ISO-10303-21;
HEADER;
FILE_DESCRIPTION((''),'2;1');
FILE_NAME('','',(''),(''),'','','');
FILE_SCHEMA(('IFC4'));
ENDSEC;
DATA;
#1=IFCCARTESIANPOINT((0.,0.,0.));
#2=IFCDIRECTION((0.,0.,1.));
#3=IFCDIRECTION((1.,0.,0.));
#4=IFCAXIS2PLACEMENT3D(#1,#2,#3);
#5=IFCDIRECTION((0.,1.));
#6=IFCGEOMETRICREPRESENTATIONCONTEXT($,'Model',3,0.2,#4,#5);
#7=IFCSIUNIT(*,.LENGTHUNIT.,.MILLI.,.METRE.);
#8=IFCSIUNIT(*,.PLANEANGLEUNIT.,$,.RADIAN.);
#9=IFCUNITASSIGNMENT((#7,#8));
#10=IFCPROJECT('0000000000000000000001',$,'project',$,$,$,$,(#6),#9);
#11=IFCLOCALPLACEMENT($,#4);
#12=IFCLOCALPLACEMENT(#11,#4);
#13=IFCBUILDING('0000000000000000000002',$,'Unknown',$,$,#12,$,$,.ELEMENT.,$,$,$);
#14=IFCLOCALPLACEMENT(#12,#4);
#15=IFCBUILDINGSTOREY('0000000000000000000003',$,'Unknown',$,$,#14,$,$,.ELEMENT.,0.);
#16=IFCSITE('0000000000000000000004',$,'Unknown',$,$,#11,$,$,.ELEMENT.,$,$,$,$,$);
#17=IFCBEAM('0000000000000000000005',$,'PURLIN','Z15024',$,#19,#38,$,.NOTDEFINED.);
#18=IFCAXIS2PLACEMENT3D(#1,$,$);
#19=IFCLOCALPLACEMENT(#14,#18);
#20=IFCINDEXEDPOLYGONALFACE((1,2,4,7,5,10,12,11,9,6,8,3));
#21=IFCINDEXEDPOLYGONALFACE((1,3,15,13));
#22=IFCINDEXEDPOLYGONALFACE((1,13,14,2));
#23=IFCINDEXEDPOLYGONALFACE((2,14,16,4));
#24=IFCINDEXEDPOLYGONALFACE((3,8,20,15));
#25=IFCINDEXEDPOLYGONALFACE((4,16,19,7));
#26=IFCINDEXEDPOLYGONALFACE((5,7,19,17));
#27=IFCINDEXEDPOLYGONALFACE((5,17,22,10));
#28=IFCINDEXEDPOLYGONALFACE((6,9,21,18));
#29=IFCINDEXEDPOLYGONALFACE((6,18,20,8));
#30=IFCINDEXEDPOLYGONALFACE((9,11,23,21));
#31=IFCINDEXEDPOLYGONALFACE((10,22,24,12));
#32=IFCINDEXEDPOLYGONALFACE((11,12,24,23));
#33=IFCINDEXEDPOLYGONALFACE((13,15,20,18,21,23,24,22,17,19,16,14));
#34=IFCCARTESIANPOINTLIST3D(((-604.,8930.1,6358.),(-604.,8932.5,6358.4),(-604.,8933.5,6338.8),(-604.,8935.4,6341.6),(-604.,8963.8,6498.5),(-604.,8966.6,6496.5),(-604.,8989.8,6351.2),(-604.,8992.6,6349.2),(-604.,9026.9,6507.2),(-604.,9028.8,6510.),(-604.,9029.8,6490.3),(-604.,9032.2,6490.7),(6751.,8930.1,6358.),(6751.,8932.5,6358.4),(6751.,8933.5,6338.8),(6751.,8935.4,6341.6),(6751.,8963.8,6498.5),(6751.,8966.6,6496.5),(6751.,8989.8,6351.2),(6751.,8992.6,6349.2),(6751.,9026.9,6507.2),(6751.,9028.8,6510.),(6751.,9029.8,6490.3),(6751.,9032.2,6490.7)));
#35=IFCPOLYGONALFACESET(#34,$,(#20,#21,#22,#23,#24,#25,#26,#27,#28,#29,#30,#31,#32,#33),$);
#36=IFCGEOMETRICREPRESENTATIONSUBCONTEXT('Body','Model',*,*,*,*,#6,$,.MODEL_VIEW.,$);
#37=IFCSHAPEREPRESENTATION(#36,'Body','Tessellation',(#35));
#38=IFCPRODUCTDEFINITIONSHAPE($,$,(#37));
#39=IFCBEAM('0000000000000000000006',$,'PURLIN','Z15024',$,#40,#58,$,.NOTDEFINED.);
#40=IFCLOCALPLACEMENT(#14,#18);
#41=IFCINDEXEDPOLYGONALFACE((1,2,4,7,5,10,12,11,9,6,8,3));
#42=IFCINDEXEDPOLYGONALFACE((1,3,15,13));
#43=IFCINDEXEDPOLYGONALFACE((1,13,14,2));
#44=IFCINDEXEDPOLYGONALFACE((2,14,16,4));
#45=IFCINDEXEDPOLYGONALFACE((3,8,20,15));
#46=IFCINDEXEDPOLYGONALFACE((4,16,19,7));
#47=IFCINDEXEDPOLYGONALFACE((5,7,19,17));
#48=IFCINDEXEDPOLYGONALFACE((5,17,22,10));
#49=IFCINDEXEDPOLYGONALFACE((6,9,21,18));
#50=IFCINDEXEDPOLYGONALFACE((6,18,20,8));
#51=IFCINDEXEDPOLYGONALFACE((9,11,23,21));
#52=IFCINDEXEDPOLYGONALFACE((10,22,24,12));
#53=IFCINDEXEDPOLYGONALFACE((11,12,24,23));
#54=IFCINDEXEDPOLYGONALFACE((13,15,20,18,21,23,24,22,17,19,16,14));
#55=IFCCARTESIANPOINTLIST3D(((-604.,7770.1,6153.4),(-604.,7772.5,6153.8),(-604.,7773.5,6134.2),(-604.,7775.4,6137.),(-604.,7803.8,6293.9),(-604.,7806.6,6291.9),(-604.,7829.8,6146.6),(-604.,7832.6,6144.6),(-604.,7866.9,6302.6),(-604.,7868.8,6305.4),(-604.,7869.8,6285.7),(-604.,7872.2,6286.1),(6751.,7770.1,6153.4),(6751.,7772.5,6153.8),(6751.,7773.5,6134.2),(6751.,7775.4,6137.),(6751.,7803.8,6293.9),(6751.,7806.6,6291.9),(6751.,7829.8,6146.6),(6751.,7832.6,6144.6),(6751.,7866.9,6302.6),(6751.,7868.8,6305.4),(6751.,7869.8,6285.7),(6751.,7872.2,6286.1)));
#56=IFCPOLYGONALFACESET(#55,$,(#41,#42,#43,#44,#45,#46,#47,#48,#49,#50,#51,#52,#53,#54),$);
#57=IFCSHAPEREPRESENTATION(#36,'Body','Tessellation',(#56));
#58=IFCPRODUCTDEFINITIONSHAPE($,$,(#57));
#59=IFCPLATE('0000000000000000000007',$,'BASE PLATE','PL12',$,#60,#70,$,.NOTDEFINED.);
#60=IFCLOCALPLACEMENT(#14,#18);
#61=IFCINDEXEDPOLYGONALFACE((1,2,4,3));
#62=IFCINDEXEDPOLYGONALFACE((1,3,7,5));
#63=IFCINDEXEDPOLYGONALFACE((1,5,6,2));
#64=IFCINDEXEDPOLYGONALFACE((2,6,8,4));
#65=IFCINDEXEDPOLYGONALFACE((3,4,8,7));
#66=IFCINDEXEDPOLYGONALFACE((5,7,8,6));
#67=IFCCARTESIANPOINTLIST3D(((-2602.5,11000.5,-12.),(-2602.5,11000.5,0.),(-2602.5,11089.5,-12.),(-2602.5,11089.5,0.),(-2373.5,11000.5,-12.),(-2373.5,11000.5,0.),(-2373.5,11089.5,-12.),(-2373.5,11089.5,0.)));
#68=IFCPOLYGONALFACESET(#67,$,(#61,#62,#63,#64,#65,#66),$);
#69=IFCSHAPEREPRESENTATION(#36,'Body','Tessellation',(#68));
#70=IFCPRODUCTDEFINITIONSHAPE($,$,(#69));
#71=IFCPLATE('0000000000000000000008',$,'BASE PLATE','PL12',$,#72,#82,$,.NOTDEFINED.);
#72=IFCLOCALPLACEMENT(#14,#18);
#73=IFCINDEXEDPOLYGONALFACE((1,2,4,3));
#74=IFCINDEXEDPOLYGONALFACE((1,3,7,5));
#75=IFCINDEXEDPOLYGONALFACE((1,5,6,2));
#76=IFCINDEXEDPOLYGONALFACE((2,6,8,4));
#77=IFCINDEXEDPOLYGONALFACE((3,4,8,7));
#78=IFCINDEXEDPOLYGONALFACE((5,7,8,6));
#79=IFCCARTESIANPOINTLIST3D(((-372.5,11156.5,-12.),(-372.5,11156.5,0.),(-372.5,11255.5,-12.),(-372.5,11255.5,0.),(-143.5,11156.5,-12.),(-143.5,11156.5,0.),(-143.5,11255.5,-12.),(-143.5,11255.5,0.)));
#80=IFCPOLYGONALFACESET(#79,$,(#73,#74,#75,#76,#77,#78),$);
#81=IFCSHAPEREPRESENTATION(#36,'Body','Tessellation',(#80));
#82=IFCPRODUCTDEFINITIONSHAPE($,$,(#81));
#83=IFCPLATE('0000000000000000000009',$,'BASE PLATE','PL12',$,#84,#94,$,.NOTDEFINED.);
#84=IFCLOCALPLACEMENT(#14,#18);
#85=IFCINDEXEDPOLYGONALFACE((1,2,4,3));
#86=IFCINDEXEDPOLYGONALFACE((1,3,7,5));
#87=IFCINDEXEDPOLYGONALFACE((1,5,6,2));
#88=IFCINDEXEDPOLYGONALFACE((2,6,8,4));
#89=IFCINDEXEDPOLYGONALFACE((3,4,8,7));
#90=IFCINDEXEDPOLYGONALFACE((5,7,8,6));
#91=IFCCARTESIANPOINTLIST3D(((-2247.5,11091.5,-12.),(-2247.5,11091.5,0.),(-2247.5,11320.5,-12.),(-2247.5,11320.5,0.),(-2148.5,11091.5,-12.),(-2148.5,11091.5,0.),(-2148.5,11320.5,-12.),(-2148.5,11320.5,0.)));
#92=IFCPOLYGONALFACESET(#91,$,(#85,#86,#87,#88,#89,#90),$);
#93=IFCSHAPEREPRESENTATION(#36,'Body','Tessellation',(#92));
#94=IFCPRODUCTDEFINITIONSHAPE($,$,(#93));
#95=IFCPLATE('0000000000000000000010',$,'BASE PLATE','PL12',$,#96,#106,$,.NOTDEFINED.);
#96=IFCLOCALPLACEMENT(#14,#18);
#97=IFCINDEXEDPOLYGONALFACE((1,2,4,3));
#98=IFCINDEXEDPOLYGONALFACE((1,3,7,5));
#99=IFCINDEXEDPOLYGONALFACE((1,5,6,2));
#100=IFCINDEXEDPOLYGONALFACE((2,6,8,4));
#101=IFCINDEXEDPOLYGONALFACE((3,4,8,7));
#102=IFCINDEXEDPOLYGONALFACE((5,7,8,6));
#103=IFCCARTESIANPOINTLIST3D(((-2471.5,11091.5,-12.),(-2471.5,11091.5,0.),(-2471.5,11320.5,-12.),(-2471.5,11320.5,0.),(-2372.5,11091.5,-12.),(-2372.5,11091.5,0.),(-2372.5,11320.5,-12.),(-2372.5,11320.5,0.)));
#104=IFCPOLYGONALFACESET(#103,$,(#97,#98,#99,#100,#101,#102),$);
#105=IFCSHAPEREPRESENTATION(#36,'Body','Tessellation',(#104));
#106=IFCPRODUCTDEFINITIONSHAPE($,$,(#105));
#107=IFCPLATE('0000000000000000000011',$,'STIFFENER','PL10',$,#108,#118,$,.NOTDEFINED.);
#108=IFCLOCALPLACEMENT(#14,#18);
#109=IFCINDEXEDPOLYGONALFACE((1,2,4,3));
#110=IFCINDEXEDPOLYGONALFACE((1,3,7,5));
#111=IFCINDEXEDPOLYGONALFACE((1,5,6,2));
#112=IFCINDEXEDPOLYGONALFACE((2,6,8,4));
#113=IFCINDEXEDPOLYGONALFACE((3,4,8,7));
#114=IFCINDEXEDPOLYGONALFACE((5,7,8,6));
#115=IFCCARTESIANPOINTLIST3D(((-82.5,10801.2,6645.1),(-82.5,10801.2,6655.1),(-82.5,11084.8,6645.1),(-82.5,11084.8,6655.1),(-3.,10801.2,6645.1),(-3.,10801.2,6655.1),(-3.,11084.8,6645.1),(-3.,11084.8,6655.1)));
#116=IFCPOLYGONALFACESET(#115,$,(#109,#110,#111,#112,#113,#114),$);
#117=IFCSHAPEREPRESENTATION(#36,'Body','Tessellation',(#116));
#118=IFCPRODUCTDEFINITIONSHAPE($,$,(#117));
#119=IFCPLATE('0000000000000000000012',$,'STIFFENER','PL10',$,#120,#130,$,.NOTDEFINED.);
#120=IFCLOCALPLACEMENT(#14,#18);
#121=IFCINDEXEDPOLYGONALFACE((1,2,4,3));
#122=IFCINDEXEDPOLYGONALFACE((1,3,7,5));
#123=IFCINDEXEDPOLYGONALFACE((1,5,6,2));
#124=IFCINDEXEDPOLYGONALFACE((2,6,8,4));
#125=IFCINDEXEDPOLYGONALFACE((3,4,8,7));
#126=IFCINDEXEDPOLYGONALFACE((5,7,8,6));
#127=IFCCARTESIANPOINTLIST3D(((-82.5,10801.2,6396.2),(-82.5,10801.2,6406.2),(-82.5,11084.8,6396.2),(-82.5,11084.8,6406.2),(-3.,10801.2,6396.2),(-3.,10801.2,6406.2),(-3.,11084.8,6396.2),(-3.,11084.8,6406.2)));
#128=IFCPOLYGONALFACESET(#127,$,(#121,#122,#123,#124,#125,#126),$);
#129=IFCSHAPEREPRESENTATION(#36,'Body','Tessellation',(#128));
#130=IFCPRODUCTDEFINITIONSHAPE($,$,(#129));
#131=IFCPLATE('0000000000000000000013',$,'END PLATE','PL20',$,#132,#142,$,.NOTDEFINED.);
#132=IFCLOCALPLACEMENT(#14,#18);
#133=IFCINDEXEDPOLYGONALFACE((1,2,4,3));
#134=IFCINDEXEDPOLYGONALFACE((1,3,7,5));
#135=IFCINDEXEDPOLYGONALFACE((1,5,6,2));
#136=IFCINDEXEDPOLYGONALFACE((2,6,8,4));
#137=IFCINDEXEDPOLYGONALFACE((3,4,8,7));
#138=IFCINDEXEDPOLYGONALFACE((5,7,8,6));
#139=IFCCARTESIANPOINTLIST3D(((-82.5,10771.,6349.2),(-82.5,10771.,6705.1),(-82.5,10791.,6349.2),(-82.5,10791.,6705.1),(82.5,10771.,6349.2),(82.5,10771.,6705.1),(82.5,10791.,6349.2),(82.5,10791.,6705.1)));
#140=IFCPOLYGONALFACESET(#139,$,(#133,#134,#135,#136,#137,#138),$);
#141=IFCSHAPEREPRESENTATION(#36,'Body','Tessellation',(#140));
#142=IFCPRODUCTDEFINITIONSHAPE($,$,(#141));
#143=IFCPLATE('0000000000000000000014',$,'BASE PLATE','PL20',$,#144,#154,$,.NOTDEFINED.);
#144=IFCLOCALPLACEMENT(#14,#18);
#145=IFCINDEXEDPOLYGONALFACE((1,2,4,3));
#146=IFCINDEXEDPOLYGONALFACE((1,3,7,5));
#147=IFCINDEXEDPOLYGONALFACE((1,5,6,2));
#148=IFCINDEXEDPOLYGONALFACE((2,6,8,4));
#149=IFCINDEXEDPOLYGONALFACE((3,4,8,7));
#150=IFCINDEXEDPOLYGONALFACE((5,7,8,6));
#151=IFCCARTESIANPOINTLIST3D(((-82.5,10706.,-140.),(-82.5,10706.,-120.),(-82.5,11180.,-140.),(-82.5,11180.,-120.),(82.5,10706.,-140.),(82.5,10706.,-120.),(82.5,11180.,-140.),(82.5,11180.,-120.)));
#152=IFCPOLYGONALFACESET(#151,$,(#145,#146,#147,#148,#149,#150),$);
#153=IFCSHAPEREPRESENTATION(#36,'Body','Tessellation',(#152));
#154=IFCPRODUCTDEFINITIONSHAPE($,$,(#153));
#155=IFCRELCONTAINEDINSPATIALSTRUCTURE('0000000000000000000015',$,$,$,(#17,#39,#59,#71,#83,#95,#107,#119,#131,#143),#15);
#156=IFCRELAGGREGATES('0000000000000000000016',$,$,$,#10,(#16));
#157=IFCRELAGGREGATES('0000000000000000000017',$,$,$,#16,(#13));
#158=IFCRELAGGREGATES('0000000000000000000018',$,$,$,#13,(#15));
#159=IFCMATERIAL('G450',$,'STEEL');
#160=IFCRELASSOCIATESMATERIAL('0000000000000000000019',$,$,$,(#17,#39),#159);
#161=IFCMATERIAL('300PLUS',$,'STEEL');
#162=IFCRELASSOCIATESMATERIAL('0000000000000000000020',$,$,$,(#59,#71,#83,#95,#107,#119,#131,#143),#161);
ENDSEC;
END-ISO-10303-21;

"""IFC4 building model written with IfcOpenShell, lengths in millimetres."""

from ifc_helpers import new_model, si_unit, direction, frame, origin_with_axes, place, context, subcontext, project, spatial, line, indexed_curve, outline, extrude, material, element, save


model = new_model("IFC4")

# Units and contexts
model_context = context("Model", 3, precision=0.2, world=origin_with_axes(), true_north=direction((0.0, 1.0)))
body_context = subcontext(model_context, "Body", "Model", "MODEL_VIEW")
ifc_project = project(units=[si_unit("LENGTHUNIT", "METRE", prefix="MILLI"), si_unit("PLANEANGLEUNIT", "RADIAN")], contexts=[model_context])

# Site, building, storey
site_placement = place(None, origin_with_axes())
site = spatial("IfcSite", under=ifc_project, at=site_placement, Name="Unknown", CompositionType="ELEMENT")
building_placement = place(site_placement, origin_with_axes())
building = spatial("IfcBuilding", under=site, at=building_placement, Name="Unknown", CompositionType="ELEMENT")
storey_placement = place(building_placement, origin_with_axes())
storey = spatial("IfcBuildingStorey", under=building, at=storey_placement, Name="Unknown", CompositionType="ELEMENT", Elevation=0.0)

# Beams
ifc_material_1 = material(Name="G450", Category="STEEL")
for number, where, z_axis, x_axis, name in (
    (1, (-604.0, 8978.2, 6423.9), (0.0, -0.984808, -0.173648), (1.0, 0.0, 0.0), "PURLIN"),
    (2, (-604.0, 7818.2, 6219.3), (0.0, -0.984808, -0.173648), (1.0, 0.0, 0.0), "PURLIN"),
):
    element("IfcBeam", number, at=place(storey_placement, frame(where, z_axis=z_axis, x_axis=x_axis)), inside=storey, material=ifc_material_1, Name=name, Description="Z15024", PredefinedType="NOTDEFINED", context=body_context, shape_type="SolidModel", body=[
        extrude(outline(indexed_curve([(58.8, -76.0), (58.8, -56.5), (56.4, -56.5), (56.4, -73.6), (1.2, -73.6), (1.2, 76.0), (-64.8, 76.0), (-64.8, 56.5), (-62.4, 56.5), (-62.4, 73.6), (-1.2, 73.6), (-1.2, -76.0)], segments=[line(1, 2, 3, 4, 5, 6, 7, 8, 9, 10, 11, 12, 1)])), frame((0.0, 0.0, 0.0), z_axis=(-1.0, 0.0, 0.0), x_axis=(0.0, 0.0, 1.0)), (0.0, 0.0, -1.0), 7355.0),
    ])

# Plates
ifc_material_2 = material(Name="300PLUS", Category="STEEL")
plate_1_placement = place(storey_placement, frame((-2602.5, 11000.5, -6.0), z_axis=(0.0, 0.0, 1.0), x_axis=(1.0, 0.0, 0.0)))
element("IfcPlate", 3, at=plate_1_placement, inside=storey, material=ifc_material_2, Name="BASE PLATE", Description="PL12", PredefinedType="NOTDEFINED", context=body_context, shape_type="SolidModel", body=[
    extrude(outline(indexed_curve([(0.0, 0.0), (229.0, 0.0), (229.0, 89.0), (0.0, 89.0)], segments=[line(1, 2, 3, 4, 1)])), frame((0.0, 0.0, 6.0), z_axis=(0.0, 0.0, 1.0), x_axis=(1.0, 0.0, 0.0)), (0.0, 0.0, -1.0), 12.0),
])
plate_2_placement = place(storey_placement, frame((-372.5, 11156.5, -6.0), z_axis=(0.0, 0.0, 1.0), x_axis=(1.0, 0.0, 0.0)))
element("IfcPlate", 4, at=plate_2_placement, inside=storey, material=ifc_material_2, Name="BASE PLATE", Description="PL12", PredefinedType="NOTDEFINED", context=body_context, shape_type="SolidModel", body=[
    extrude(outline(indexed_curve([(0.0, 0.0), (229.0, 0.0), (229.0, 99.0), (0.0, 99.0)], segments=[line(1, 2, 3, 4, 1)])), frame((0.0, 0.0, 6.0), z_axis=(0.0, 0.0, 1.0), x_axis=(1.0, 0.0, 0.0)), (0.0, 0.0, -1.0), 12.0),
])
for number, where, z_axis, x_axis, name in (
    (5, (-2247.5, 11091.5, -6.0), (0.0, 0.0, 1.0), (1.0, 0.0, 0.0), "BASE PLATE"),
    (6, (-2471.5, 11091.5, -6.0), (0.0, 0.0, 1.0), (1.0, 0.0, 0.0), "BASE PLATE"),
):
    element("IfcPlate", number, at=place(storey_placement, frame(where, z_axis=z_axis, x_axis=x_axis)), inside=storey, material=ifc_material_2, Name=name, Description="PL12", PredefinedType="NOTDEFINED", context=body_context, shape_type="SolidModel", body=[
        extrude(outline(indexed_curve([(0.0, 0.0), (99.0, 0.0), (99.0, 229.0), (0.0, 229.0)], segments=[line(1, 2, 3, 4, 1)])), frame((0.0, 0.0, 6.0), z_axis=(0.0, 0.0, 1.0), x_axis=(1.0, 0.0, 0.0)), (0.0, 0.0, -1.0), 12.0),
    ])
for number, where, z_axis, x_axis, name in (
    (7, (-82.5, 10801.2, 6650.1), (0.0, 0.0, 1.0), (1.0, 0.0, 0.0), "STIFFENER"),
    (8, (-82.5, 10801.2, 6401.2), (0.0, 0.0, 1.0), (1.0, 0.0, 0.0), "STIFFENER"),
):
    element("IfcPlate", number, at=place(storey_placement, frame(where, z_axis=z_axis, x_axis=x_axis)), inside=storey, material=ifc_material_2, Name=name, Description="PL10", PredefinedType="NOTDEFINED", context=body_context, shape_type="SolidModel", body=[
        extrude(outline(indexed_curve([(0.0, 0.0), (79.5, 0.0), (79.5, 283.6), (0.0, 283.6)], segments=[line(1, 2, 3, 4, 1)])), frame((0.0, 0.0, 5.0), z_axis=(0.0, 0.0, 1.0), x_axis=(1.0, 0.0, 0.0)), (0.0, 0.0, -1.0), 10.0),
    ])
plate_3_placement = place(storey_placement, frame((-82.5, 10781.0, 6349.2), z_axis=(0.0, -1.0, 0.0), x_axis=(1.0, 0.0, 0.0)))
element("IfcPlate", 9, at=plate_3_placement, inside=storey, material=ifc_material_2, Name="END PLATE", Description="PL20", PredefinedType="NOTDEFINED", context=body_context, shape_type="SolidModel", body=[
    extrude(outline(indexed_curve([(0.0, 0.0), (165.0, 0.0), (165.0, 355.9), (0.0, 355.9)], segments=[line(1, 2, 3, 4, 1)])), frame((0.0, 0.0, 10.0), z_axis=(0.0, 0.0, 1.0), x_axis=(1.0, 0.0, 0.0)), (0.0, 0.0, -1.0), 20.0),
])
plate_4_placement = place(storey_placement, frame((-82.5, 10706.0, -130.0), z_axis=(0.0, 0.0, 1.0), x_axis=(1.0, 0.0, 0.0)))
element("IfcPlate", 10, at=plate_4_placement, inside=storey, material=ifc_material_2, Name="BASE PLATE", Description="PL20", PredefinedType="NOTDEFINED", context=body_context, shape_type="SolidModel", body=[
    extrude(outline(indexed_curve([(0.0, 0.0), (165.0, 0.0), (165.0, 474.0), (0.0, 474.0)], segments=[line(1, 2, 3, 4, 1)])), frame((0.0, 0.0, 10.0), z_axis=(0.0, 0.0, 1.0), x_axis=(1.0, 0.0, 0.0)), (0.0, 0.0, -1.0), 20.0),
])

save(model, "model.ifc")
